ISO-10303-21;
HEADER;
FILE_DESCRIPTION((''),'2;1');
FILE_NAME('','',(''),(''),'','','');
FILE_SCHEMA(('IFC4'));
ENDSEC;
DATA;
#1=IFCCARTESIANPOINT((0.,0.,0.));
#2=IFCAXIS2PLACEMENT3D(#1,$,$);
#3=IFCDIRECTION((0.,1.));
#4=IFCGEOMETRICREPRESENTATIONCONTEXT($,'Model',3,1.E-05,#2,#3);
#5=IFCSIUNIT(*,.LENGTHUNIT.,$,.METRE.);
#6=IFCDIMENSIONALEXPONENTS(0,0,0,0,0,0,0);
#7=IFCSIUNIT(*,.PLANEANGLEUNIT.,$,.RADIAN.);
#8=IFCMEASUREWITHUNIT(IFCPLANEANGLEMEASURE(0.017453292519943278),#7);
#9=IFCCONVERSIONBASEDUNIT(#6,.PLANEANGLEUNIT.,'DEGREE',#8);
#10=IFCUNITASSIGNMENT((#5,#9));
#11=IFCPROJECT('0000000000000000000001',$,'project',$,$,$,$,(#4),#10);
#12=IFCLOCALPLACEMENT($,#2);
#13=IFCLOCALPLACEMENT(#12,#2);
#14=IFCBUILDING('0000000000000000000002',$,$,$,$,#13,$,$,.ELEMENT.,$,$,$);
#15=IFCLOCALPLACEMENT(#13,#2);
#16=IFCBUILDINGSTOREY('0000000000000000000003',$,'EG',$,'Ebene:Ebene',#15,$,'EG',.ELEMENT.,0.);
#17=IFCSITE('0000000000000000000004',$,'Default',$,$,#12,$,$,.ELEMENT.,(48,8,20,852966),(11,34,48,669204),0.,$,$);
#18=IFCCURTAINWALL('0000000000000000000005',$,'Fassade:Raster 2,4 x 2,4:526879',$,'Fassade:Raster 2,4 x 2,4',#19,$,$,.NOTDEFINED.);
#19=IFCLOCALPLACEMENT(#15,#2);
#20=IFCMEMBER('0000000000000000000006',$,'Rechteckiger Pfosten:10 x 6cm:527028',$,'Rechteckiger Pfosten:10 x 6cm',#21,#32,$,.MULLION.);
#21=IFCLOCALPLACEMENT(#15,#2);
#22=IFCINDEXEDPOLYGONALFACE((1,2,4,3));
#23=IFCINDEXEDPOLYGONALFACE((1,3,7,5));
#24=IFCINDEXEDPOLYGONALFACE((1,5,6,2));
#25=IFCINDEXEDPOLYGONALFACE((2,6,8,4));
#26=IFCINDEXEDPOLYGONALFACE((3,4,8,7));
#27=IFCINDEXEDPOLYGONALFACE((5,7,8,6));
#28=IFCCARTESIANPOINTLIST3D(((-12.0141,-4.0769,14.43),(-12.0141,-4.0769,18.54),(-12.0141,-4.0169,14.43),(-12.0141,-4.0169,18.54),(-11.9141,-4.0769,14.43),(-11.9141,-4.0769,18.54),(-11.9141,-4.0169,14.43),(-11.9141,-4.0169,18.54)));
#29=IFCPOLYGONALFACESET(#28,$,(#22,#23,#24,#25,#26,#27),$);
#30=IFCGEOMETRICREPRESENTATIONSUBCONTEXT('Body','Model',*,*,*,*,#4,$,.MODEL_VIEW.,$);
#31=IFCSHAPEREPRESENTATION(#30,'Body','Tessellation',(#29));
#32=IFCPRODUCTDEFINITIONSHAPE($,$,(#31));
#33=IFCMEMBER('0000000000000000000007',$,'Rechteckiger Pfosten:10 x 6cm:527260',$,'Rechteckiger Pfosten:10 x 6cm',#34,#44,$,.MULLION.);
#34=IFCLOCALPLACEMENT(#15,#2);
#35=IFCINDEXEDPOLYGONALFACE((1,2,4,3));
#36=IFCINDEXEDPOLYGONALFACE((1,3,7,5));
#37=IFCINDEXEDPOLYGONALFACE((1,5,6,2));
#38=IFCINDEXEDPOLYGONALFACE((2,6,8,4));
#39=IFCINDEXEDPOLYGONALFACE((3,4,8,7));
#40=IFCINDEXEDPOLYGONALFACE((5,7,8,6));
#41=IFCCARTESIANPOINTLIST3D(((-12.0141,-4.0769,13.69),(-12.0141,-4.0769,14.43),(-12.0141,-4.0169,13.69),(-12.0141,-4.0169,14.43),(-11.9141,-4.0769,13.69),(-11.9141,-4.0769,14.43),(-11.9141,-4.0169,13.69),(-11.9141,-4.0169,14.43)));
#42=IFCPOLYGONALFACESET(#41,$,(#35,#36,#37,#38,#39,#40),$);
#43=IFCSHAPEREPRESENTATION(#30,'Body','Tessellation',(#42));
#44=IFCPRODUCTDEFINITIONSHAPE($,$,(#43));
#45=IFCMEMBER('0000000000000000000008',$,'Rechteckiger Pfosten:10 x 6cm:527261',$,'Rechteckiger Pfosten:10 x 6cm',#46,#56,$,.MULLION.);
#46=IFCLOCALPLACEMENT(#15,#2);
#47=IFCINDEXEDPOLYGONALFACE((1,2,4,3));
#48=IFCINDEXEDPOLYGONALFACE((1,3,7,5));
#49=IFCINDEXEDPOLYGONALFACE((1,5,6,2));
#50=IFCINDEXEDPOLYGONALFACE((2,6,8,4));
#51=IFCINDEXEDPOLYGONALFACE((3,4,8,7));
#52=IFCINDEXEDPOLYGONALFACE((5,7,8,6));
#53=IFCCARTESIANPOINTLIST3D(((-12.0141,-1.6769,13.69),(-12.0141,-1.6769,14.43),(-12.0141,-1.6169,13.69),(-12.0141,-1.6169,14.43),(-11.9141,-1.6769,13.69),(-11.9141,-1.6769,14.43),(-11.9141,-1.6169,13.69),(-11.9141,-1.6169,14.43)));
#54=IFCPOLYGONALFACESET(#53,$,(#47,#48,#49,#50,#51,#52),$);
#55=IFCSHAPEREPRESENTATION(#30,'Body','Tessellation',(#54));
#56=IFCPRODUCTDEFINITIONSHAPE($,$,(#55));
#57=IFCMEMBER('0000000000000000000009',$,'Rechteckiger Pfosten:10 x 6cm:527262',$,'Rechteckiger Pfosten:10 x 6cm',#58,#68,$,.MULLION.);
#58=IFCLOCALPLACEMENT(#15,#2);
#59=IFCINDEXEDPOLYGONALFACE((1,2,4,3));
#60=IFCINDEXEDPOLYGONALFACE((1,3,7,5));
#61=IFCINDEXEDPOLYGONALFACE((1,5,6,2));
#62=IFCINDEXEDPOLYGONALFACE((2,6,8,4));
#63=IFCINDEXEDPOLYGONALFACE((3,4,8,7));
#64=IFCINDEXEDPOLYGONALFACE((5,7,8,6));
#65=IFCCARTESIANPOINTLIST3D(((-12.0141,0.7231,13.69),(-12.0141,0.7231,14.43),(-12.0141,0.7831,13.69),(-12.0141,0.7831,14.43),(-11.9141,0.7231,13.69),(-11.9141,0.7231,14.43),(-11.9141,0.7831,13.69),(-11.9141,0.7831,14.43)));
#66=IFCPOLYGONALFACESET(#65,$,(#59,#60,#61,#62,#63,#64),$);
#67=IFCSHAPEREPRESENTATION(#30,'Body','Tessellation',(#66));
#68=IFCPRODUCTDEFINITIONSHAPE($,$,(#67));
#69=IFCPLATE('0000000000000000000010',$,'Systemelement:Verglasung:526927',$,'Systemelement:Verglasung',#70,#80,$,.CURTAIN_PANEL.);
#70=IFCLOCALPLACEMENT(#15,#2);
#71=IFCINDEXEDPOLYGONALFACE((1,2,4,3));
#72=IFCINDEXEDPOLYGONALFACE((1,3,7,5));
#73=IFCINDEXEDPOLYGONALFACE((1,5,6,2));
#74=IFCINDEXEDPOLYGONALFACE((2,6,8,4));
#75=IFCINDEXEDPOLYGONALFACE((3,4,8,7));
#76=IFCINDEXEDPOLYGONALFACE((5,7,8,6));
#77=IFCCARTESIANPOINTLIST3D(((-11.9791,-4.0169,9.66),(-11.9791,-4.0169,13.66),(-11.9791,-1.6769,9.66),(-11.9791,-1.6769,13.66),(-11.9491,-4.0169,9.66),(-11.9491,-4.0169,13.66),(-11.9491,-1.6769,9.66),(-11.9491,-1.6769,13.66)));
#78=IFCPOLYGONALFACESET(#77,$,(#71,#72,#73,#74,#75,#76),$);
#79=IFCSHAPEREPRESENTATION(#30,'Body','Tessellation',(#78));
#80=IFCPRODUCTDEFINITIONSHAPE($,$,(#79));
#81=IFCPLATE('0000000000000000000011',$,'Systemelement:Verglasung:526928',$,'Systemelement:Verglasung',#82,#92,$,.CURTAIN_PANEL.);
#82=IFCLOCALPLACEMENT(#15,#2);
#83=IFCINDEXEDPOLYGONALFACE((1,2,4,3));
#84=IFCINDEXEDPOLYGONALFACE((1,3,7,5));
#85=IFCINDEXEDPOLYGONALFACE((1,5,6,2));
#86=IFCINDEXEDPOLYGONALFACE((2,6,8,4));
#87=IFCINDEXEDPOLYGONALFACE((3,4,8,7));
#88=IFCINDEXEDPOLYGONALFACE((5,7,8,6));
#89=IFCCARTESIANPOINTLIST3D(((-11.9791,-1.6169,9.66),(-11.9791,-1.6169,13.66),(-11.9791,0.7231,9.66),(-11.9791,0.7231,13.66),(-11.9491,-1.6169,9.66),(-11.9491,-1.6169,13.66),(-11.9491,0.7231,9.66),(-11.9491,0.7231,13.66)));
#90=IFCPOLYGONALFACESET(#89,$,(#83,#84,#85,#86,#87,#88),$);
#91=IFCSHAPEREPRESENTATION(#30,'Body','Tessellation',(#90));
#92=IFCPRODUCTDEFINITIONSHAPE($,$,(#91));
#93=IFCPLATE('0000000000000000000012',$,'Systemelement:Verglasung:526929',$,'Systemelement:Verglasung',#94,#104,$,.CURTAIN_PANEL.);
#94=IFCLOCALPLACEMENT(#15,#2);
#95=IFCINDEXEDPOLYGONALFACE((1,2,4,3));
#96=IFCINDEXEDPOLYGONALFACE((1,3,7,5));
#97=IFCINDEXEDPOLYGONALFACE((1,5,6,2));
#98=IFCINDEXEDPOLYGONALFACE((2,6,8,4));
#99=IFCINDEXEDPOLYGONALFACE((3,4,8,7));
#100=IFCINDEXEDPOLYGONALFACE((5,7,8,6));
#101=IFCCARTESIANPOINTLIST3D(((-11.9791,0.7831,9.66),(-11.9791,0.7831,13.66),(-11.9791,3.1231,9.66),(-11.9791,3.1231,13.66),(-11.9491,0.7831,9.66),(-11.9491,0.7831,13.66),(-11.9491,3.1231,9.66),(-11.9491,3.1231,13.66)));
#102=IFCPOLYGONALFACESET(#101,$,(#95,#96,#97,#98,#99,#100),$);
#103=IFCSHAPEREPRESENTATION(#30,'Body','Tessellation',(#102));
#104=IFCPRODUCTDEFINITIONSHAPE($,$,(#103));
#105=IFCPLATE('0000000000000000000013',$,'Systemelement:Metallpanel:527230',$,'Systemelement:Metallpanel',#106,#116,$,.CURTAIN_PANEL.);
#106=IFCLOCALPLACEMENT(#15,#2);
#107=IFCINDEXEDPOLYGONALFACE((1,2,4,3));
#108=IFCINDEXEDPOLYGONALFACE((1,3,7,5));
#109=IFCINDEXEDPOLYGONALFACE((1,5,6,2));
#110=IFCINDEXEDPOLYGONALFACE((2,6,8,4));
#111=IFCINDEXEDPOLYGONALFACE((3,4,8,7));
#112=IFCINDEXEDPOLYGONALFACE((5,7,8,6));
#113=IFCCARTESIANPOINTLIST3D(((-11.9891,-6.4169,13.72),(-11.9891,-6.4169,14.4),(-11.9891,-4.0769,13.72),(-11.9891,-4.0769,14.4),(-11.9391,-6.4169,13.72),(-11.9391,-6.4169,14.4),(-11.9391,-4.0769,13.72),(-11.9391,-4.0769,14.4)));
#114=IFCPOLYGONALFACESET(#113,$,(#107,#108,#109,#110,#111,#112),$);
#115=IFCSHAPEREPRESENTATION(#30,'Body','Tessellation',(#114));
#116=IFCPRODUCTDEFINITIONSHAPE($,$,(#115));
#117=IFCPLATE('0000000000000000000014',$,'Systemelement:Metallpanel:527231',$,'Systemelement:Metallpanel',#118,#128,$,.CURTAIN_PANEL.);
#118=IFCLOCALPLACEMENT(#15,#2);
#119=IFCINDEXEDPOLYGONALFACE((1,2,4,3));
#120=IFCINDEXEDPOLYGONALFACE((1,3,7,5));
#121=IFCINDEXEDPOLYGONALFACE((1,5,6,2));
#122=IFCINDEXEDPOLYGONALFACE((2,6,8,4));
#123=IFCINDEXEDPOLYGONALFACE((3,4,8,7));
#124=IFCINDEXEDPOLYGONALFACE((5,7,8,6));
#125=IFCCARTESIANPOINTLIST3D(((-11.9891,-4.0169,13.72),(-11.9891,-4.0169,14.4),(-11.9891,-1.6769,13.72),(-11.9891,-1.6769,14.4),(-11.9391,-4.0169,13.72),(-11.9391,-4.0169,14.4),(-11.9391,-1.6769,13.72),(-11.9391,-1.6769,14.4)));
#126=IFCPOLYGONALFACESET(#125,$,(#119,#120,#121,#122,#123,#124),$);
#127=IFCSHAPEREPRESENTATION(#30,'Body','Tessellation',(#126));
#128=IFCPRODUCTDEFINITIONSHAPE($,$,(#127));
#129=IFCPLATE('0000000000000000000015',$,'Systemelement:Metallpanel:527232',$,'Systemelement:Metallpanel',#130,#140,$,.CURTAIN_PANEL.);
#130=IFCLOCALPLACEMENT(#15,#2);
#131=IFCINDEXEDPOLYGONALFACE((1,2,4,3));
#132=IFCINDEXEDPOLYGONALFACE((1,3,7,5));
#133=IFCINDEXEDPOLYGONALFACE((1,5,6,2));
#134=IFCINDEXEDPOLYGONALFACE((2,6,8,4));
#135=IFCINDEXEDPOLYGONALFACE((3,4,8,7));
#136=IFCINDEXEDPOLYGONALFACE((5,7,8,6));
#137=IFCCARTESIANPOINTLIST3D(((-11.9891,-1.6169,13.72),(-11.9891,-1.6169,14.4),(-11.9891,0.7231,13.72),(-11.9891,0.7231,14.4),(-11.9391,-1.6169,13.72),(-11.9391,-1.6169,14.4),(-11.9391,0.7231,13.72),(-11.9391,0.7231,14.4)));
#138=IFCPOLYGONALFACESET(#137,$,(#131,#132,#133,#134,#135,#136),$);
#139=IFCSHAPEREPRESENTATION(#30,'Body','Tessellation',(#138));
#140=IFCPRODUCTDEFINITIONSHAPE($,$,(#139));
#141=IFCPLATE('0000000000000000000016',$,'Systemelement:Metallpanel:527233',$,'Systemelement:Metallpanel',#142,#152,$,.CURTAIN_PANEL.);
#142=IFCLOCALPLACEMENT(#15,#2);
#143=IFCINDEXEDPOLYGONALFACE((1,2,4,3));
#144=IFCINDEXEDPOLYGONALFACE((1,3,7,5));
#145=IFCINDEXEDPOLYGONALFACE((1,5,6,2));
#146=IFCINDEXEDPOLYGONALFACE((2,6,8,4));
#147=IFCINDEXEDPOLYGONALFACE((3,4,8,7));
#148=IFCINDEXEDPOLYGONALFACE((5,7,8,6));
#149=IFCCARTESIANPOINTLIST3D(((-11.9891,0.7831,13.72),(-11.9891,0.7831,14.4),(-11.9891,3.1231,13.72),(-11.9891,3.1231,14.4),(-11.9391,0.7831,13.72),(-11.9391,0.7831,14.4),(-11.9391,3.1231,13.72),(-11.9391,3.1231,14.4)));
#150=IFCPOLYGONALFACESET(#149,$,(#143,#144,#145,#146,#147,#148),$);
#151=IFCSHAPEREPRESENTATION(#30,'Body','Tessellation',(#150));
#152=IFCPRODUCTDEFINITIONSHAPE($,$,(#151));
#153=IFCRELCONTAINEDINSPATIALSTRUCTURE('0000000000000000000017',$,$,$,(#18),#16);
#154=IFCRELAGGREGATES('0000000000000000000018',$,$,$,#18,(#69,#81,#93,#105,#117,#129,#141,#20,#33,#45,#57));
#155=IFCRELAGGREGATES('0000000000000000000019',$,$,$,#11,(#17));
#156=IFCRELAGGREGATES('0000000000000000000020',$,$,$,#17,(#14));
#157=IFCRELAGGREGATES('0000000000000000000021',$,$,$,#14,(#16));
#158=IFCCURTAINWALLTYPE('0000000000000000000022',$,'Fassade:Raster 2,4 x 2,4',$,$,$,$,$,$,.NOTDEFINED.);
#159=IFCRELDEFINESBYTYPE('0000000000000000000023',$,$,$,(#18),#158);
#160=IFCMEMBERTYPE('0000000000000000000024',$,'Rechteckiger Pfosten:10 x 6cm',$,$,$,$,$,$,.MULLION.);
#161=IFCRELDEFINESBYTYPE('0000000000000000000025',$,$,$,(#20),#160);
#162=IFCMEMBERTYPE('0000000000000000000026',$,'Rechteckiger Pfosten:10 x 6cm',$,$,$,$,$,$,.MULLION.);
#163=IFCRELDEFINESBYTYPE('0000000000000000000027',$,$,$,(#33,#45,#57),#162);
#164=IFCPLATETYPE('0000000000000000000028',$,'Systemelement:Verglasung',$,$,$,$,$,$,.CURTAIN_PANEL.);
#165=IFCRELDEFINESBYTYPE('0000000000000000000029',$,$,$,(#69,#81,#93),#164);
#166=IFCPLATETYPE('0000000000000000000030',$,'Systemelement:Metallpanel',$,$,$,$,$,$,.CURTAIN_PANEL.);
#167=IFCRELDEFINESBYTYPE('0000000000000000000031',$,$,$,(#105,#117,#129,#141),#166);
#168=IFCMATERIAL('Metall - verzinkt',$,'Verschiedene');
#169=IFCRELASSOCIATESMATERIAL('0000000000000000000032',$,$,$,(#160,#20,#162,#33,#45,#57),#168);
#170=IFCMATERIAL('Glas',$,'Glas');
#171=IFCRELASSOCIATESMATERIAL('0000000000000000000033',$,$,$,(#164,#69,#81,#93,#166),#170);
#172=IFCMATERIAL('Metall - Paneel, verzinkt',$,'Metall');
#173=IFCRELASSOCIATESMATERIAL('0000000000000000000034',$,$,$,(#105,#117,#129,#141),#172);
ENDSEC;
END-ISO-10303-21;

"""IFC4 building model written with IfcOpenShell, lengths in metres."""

from ifc_helpers import new_model, entity, si_unit, converted_unit, direction, frame, origin, place, context, subcontext, project, spatial, indexed_curve, outline, extrude, source, transform, mapped, material, type_object, type_shapes, element, aggregate, save


model = new_model("IFC4")

# Units and contexts
model_context = context("Model", 3, precision=1e-05, world=origin(), true_north=direction((0.0, 1.0)))
body_context = subcontext(model_context, "Body", "Model", "MODEL_VIEW")
ifc_project = project(units=[si_unit("LENGTHUNIT", "METRE"), converted_unit("PLANEANGLEUNIT", "DEGREE", entity("IfcPlaneAngleMeasure", 0.017453292519943278), si_unit("PLANEANGLEUNIT", "RADIAN"), dimensions=[0, 0, 0, 0, 0, 0, 0])], contexts=[model_context])

# Site, building, storey
site_placement = place(None, origin())
site = spatial("IfcSite", under=ifc_project, at=site_placement, Name="Default", CompositionType="ELEMENT", RefLatitude=(48, 8, 20, 852966), RefLongitude=(11, 34, 48, 669204), RefElevation=0.0)
building_placement = place(site_placement, origin())
building = spatial("IfcBuilding", under=site, at=building_placement, CompositionType="ELEMENT")
storey_placement = place(building_placement, origin())
storey = spatial("IfcBuildingStorey", under=building, at=storey_placement, Name="EG", ObjectType="Ebene:Ebene", LongName="EG", CompositionType="ELEMENT", Elevation=0.0)

# Curtain wall, members, plates
curtain_wall_type = type_object("IfcCurtainWallType", Name="Fassade:Raster 2,4 x 2,4", PredefinedType="NOTDEFINED")
curtain_wall_placement = place(storey_placement, origin())
curtain_wall = element("IfcCurtainWall", 1, at=curtain_wall_placement, inside=storey, type_object=curtain_wall_type, Name="Fassade:Raster 2,4 x 2,4:526879", ObjectType="Fassade:Raster 2,4 x 2,4", PredefinedType="NOTDEFINED")
ifc_material_1 = material(Name="Metall - verzinkt", Category="Verschiedene")
member_type_1 = type_object("IfcMemberType", Name="Rechteckiger Pfosten:10 x 6cm", PredefinedType="MULLION", material=ifc_material_1)
shared_shape_1 = source(origin(), body_context, "Body", "SweptSolid", [
    extrude(outline(indexed_curve([(-0.03, -0.05), (0.03, -0.05), (0.03, 0.05), (-0.03, 0.05), (-0.03, -0.05)], self_intersect=False)), frame((0.0, 0.0, -4.11), z_axis=(0.0, 0.0, 1.0), x_axis=(-1.0, 0.0, 0.0)), (0.0, 0.0, 1.0), 4.11),
])
type_shapes(member_type_1, [shared_shape_1])
member_1_placement = place(curtain_wall_placement, frame((-11.9641, -4.0469, 14.43), z_axis=(0.0, 0.0, -1.0), x_axis=(0.0, 1.0, 0.0)))
member_1 = element("IfcMember", 2, at=member_1_placement, type_object=member_type_1, material=ifc_material_1, Name="Rechteckiger Pfosten:10 x 6cm:527028", ObjectType="Rechteckiger Pfosten:10 x 6cm", PredefinedType="MULLION", context=body_context, shape_type="MappedRepresentation", body=[
    mapped(shared_shape_1, transform((0.0, 0.0, 0.0), scale=1.0)),
])
member_type_2 = type_object("IfcMemberType", Name="Rechteckiger Pfosten:10 x 6cm", PredefinedType="MULLION", material=ifc_material_1)
shared_shape_2 = source(origin(), body_context, "Body", "SweptSolid", [
    extrude(outline(indexed_curve([(-0.03, -0.05), (0.03, -0.05), (0.03, 0.05), (-0.03, 0.05), (-0.03, -0.05)], self_intersect=False)), frame((0.0, 0.0, -0.74), z_axis=(0.0, 0.0, 1.0), x_axis=(-1.0, 0.0, 0.0)), (0.0, 0.0, 1.0), 0.74),
])
type_shapes(member_type_2, [shared_shape_2])
member_2_placement = place(curtain_wall_placement, frame((-11.9641, -4.0469, 13.69), z_axis=(0.0, 0.0, -1.0), x_axis=(0.0, 1.0, 0.0)))
member_2 = element("IfcMember", 3, at=member_2_placement, type_object=member_type_2, material=ifc_material_1, Name="Rechteckiger Pfosten:10 x 6cm:527260", ObjectType="Rechteckiger Pfosten:10 x 6cm", PredefinedType="MULLION", context=body_context, shape_type="MappedRepresentation", body=[
    mapped(shared_shape_2, transform((0.0, 0.0, 0.0), scale=1.0)),
])
member_3_placement = place(curtain_wall_placement, frame((-11.9641, -1.6469, 13.69), z_axis=(0.0, 0.0, -1.0), x_axis=(0.0, 1.0, 0.0)))
member_3 = element("IfcMember", 4, at=member_3_placement, type_object=member_type_2, material=ifc_material_1, Name="Rechteckiger Pfosten:10 x 6cm:527261", ObjectType="Rechteckiger Pfosten:10 x 6cm", PredefinedType="MULLION", context=body_context, shape_type="MappedRepresentation", body=[
    mapped(shared_shape_2, transform((0.0, 0.0, 0.0), scale=1.0)),
])
member_4_placement = place(curtain_wall_placement, frame((-11.9641, 0.7531, 13.69), z_axis=(0.0, 0.0, -1.0), x_axis=(0.0, 1.0, 0.0)))
member_4 = element("IfcMember", 5, at=member_4_placement, type_object=member_type_2, material=ifc_material_1, Name="Rechteckiger Pfosten:10 x 6cm:527262", ObjectType="Rechteckiger Pfosten:10 x 6cm", PredefinedType="MULLION", context=body_context, shape_type="MappedRepresentation", body=[
    mapped(shared_shape_2, transform((0.0, 0.0, 0.0), scale=1.0)),
])
ifc_material_2 = material(Name="Glas", Category="Glas")
plate_type_1 = type_object("IfcPlateType", Name="Systemelement:Verglasung", PredefinedType="CURTAIN_PANEL", material=ifc_material_2)
shared_shape_3 = source(origin(), body_context, "Body", "SweptSolid", [
    extrude(outline(indexed_curve([(-0.015, -1.17), (0.015, -1.17), (0.015, 1.17), (-0.015, 1.17), (-0.015, -1.17)], self_intersect=False)), frame((0.0, 0.0, 0.0), z_axis=(0.0, 0.0, 1.0), x_axis=(0.0, 1.0, 0.0)), (0.0, 0.0, 1.0), 4.0),
])
type_shapes(plate_type_1, [shared_shape_3])
plate_1_placement = place(curtain_wall_placement, frame((-11.9641, -2.8469, 9.66), z_axis=(0.0, 0.0, 1.0), x_axis=(0.0, 1.0, 0.0)))
plate_1 = element("IfcPlate", 6, at=plate_1_placement, type_object=plate_type_1, material=ifc_material_2, Name="Systemelement:Verglasung:526927", ObjectType="Systemelement:Verglasung", PredefinedType="CURTAIN_PANEL", context=body_context, shape_type="MappedRepresentation", body=[
    mapped(shared_shape_3, transform((0.0, 0.0, 0.0), scale=1.0)),
])
plate_2_placement = place(curtain_wall_placement, frame((-11.9641, -0.4469, 9.66), z_axis=(0.0, 0.0, 1.0), x_axis=(0.0, 1.0, 0.0)))
plate_2 = element("IfcPlate", 7, at=plate_2_placement, type_object=plate_type_1, material=ifc_material_2, Name="Systemelement:Verglasung:526928", ObjectType="Systemelement:Verglasung", PredefinedType="CURTAIN_PANEL", context=body_context, shape_type="MappedRepresentation", body=[
    mapped(shared_shape_3, transform((0.0, 0.0, 0.0), scale=1.0)),
])
plate_3_placement = place(curtain_wall_placement, frame((-11.9641, 1.9531, 9.66), z_axis=(0.0, 0.0, 1.0), x_axis=(0.0, 1.0, 0.0)))
plate_3 = element("IfcPlate", 8, at=plate_3_placement, type_object=plate_type_1, material=ifc_material_2, Name="Systemelement:Verglasung:526929", ObjectType="Systemelement:Verglasung", PredefinedType="CURTAIN_PANEL", context=body_context, shape_type="MappedRepresentation", body=[
    mapped(shared_shape_3, transform((0.0, 0.0, 0.0), scale=1.0)),
])
ifc_material_3 = material(Name="Metall - Paneel, verzinkt", Category="Metall")
plate_type_2 = type_object("IfcPlateType", Name="Systemelement:Metallpanel", PredefinedType="CURTAIN_PANEL", material=ifc_material_2)
shared_shape_4 = source(origin(), body_context, "Body", "SweptSolid", [
    extrude(outline(indexed_curve([(-0.025, -1.17), (0.025, -1.17), (0.025, 1.17), (-0.025, 1.17), (-0.025, -1.17)], self_intersect=False)), frame((0.0, 0.0, 0.0), z_axis=(0.0, 0.0, 1.0), x_axis=(0.0, 1.0, 0.0)), (0.0, 0.0, 1.0), 0.68),
])
type_shapes(plate_type_2, [shared_shape_4])
plate_4_placement = place(curtain_wall_placement, frame((-11.9641, -5.2469, 13.72), z_axis=(0.0, 0.0, 1.0), x_axis=(0.0, 1.0, 0.0)))
plate_4 = element("IfcPlate", 9, at=plate_4_placement, type_object=plate_type_2, material=ifc_material_3, Name="Systemelement:Metallpanel:527230", ObjectType="Systemelement:Metallpanel", PredefinedType="CURTAIN_PANEL", context=body_context, shape_type="MappedRepresentation", body=[
    mapped(shared_shape_4, transform((0.0, 0.0, 0.0), scale=1.0)),
])
plate_5_placement = place(curtain_wall_placement, frame((-11.9641, -2.8469, 13.72), z_axis=(0.0, 0.0, 1.0), x_axis=(0.0, 1.0, 0.0)))
plate_5 = element("IfcPlate", 10, at=plate_5_placement, type_object=plate_type_2, material=ifc_material_3, Name="Systemelement:Metallpanel:527231", ObjectType="Systemelement:Metallpanel", PredefinedType="CURTAIN_PANEL", context=body_context, shape_type="MappedRepresentation", body=[
    mapped(shared_shape_4, transform((0.0, 0.0, 0.0), scale=1.0)),
])
plate_6_placement = place(curtain_wall_placement, frame((-11.9641, -0.4469, 13.72), z_axis=(0.0, 0.0, 1.0), x_axis=(0.0, 1.0, 0.0)))
plate_6 = element("IfcPlate", 11, at=plate_6_placement, type_object=plate_type_2, material=ifc_material_3, Name="Systemelement:Metallpanel:527232", ObjectType="Systemelement:Metallpanel", PredefinedType="CURTAIN_PANEL", context=body_context, shape_type="MappedRepresentation", body=[
    mapped(shared_shape_4, transform((0.0, 0.0, 0.0), scale=1.0)),
])
plate_7_placement = place(curtain_wall_placement, frame((-11.9641, 1.9531, 13.72), z_axis=(0.0, 0.0, 1.0), x_axis=(0.0, 1.0, 0.0)))
plate_7 = element("IfcPlate", 12, at=plate_7_placement, type_object=plate_type_2, material=ifc_material_3, Name="Systemelement:Metallpanel:527233", ObjectType="Systemelement:Metallpanel", PredefinedType="CURTAIN_PANEL", context=body_context, shape_type="MappedRepresentation", body=[
    mapped(shared_shape_4, transform((0.0, 0.0, 0.0), scale=1.0)),
])
aggregate(curtain_wall, [plate_1, plate_2, plate_3, plate_4, plate_5, plate_6, plate_7, member_1, member_2, member_3, member_4])

save(model, "model.ifc")
